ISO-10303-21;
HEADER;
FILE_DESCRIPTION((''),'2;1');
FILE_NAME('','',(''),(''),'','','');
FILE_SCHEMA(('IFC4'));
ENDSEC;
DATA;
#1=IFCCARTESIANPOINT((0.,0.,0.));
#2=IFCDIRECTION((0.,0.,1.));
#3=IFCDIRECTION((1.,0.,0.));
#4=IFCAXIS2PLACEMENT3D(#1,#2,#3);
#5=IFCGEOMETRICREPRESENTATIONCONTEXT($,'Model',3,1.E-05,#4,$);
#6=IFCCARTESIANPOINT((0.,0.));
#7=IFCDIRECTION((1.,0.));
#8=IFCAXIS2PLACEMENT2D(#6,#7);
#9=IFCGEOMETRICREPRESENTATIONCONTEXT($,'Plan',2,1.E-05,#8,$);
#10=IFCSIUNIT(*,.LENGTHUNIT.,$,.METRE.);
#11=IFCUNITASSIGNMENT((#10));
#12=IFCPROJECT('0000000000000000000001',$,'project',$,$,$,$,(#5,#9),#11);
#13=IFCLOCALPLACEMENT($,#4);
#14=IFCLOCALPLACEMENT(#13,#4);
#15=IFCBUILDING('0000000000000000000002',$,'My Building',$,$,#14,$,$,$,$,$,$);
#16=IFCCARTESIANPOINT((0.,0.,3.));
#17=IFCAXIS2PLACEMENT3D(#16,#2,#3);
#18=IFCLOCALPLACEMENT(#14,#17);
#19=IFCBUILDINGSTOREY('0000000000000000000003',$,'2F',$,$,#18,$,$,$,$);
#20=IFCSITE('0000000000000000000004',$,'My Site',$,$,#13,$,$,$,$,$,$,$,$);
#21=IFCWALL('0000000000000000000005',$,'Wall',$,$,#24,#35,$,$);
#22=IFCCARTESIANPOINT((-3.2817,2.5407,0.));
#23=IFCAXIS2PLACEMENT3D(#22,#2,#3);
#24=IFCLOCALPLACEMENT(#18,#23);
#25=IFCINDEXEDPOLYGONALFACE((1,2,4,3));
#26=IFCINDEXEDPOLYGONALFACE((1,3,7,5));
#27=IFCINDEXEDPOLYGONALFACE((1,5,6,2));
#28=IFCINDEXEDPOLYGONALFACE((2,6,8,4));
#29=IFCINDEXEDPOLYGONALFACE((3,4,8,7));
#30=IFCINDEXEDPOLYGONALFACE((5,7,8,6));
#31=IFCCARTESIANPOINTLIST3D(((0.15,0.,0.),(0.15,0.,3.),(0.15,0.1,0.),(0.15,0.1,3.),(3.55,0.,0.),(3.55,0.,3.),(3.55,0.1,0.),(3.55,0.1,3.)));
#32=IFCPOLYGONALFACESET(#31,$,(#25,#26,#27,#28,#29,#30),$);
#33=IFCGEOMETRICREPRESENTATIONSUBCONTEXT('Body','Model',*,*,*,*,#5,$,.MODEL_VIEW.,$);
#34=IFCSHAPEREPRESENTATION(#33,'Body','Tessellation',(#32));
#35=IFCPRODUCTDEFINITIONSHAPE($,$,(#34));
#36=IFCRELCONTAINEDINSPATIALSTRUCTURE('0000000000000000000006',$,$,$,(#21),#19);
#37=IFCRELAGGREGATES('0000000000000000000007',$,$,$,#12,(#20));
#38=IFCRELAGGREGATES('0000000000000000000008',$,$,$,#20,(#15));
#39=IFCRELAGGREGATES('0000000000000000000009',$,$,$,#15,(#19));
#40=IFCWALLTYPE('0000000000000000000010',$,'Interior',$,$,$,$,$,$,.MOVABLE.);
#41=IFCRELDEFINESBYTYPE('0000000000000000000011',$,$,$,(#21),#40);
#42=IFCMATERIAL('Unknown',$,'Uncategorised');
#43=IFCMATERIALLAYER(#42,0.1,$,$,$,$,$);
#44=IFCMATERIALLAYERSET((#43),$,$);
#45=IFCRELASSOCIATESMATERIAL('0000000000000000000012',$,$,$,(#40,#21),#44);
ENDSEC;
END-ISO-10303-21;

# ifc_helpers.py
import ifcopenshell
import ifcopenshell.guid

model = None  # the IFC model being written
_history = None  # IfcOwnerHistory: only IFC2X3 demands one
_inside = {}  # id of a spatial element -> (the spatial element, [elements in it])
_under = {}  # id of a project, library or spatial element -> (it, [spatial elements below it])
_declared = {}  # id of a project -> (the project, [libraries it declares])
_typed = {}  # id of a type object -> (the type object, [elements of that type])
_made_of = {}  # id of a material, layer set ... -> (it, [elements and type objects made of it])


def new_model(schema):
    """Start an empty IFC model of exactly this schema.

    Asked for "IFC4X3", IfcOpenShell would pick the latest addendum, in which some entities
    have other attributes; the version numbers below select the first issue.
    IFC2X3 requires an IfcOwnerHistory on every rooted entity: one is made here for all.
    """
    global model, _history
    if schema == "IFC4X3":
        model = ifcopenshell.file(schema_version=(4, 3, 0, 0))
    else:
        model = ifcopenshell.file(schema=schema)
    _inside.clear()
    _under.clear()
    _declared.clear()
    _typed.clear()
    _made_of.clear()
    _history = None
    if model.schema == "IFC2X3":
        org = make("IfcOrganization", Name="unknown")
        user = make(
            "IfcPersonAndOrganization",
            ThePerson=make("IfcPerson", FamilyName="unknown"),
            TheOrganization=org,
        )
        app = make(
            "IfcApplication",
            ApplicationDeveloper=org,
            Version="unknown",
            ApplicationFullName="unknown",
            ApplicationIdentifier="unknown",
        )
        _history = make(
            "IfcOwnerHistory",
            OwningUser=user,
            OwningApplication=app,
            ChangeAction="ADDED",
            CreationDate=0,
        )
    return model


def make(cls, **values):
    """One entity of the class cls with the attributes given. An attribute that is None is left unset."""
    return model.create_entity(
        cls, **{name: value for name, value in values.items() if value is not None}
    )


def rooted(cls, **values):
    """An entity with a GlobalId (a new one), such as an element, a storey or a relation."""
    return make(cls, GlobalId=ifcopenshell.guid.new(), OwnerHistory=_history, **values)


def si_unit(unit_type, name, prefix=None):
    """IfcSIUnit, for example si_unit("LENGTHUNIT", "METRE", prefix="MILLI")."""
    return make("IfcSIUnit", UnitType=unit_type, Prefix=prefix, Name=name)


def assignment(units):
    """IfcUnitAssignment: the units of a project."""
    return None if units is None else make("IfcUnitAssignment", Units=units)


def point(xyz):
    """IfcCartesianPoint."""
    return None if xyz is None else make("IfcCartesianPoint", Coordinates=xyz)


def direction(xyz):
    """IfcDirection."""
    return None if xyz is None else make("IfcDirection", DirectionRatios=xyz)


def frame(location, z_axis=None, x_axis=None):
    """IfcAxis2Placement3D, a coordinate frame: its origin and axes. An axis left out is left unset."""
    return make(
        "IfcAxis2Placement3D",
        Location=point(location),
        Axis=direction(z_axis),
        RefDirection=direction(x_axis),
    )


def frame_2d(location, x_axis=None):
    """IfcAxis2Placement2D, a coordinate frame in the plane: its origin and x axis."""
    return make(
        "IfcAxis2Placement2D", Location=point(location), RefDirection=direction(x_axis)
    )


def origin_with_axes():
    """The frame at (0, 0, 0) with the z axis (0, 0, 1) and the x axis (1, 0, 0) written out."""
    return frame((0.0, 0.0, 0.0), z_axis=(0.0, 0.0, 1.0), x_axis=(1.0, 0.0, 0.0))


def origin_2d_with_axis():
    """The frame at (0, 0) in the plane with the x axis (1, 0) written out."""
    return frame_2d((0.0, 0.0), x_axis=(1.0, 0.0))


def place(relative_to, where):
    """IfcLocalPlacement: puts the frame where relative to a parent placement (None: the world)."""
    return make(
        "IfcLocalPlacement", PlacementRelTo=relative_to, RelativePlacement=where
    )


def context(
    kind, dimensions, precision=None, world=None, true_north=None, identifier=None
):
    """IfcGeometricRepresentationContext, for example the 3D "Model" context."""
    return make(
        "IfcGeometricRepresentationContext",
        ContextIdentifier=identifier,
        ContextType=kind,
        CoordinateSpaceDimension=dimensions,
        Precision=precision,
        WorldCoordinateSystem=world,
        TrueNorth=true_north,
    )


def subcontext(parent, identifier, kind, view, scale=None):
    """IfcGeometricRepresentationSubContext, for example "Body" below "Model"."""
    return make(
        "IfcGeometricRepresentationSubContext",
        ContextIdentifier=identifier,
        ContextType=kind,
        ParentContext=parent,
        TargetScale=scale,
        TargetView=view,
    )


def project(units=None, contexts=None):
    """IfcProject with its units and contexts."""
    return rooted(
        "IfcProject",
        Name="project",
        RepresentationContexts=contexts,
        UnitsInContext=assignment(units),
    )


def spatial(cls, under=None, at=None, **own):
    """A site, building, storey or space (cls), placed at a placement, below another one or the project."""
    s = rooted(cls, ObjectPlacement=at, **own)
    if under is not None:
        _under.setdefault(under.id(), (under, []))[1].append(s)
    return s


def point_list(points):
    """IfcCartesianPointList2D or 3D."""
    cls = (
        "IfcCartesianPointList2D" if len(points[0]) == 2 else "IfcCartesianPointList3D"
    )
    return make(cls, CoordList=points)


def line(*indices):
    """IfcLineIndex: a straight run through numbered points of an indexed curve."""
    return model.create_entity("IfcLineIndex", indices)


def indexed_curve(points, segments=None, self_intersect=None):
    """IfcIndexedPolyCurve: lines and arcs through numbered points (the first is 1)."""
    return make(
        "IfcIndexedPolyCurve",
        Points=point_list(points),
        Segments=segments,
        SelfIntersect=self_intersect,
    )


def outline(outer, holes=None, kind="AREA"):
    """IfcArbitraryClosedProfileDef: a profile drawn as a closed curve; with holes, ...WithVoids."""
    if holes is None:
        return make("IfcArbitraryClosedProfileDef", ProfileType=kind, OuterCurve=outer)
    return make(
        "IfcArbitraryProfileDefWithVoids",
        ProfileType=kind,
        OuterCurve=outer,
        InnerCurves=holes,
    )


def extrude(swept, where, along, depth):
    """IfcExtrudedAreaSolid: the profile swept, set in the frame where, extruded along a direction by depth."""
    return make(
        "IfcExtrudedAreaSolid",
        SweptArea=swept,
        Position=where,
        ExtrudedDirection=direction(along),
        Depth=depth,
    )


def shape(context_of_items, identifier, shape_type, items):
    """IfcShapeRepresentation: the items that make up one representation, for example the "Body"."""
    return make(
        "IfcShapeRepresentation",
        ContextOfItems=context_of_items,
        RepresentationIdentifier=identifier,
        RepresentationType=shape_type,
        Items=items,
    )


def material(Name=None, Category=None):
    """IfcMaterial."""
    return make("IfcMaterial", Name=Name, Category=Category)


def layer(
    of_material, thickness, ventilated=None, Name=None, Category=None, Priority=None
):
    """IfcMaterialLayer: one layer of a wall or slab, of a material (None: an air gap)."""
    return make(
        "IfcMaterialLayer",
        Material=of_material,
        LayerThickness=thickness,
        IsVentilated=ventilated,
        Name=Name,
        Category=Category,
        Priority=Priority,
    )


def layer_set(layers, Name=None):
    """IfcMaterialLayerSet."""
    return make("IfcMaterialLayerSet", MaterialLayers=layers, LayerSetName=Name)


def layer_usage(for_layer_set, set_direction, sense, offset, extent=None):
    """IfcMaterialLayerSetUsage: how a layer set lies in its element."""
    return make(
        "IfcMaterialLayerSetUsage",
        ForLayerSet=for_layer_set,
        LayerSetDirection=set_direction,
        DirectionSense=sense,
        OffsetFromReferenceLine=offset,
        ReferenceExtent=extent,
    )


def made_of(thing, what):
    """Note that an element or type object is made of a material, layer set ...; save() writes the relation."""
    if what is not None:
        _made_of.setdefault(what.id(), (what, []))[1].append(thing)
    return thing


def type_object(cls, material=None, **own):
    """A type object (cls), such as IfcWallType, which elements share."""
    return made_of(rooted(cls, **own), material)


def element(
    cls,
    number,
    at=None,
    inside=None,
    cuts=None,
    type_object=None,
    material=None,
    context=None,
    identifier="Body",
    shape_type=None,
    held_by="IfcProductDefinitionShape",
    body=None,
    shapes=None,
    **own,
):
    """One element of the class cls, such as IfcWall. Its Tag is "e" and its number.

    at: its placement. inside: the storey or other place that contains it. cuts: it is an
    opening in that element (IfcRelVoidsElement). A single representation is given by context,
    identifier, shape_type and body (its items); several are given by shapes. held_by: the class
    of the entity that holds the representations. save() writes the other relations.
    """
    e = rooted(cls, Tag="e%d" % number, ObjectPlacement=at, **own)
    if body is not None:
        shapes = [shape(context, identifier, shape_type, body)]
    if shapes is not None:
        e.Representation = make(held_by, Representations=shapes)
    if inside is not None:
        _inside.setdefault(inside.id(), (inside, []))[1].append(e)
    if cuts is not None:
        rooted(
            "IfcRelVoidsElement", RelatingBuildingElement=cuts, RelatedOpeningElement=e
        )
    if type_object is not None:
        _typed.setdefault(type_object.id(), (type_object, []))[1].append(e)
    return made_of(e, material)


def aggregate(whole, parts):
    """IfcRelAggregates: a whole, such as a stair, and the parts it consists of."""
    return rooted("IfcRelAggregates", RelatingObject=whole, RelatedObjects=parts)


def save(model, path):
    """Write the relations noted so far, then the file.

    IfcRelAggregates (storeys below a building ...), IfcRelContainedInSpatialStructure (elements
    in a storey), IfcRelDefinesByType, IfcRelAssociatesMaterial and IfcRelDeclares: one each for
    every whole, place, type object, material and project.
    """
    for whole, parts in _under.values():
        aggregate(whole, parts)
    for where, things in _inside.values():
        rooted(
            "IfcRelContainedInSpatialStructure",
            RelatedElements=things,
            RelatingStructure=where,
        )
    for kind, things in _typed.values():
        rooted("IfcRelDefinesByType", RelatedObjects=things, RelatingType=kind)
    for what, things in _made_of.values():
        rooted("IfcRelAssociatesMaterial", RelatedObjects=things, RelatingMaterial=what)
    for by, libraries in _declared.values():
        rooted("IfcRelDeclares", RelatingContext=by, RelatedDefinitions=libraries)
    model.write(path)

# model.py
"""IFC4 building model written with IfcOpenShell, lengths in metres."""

from ifc_helpers import new_model, si_unit, frame, origin_with_axes, origin_2d_with_axis, place, context, subcontext, project, spatial, line, indexed_curve, outline, extrude, material, layer, layer_set, layer_usage, type_object, element, save


model = new_model("IFC4")

# Units and contexts
model_context = context("Model", 3, precision=1e-05, world=origin_with_axes())
plan_context = context("Plan", 2, precision=1e-05, world=origin_2d_with_axis())
body_context_1 = subcontext(model_context, "Body", "Model", "MODEL_VIEW")
ifc_project = project(units=[si_unit("LENGTHUNIT", "METRE")], contexts=[model_context, plan_context])

# Site, building, storey
site_placement = place(None, origin_with_axes())
site = spatial("IfcSite", under=ifc_project, at=site_placement, Name="My Site")
building_placement = place(site_placement, origin_with_axes())
building = spatial("IfcBuilding", under=site, at=building_placement, Name="My Building")
storey_placement = place(building_placement, frame((0.0, 0.0, 3.0), z_axis=(0.0, 0.0, 1.0), x_axis=(1.0, 0.0, 0.0)))
storey = spatial("IfcBuildingStorey", under=building, at=storey_placement, Name="2F")

# Shared definitions
ifc_material = material(Name="Unknown", Category="Uncategorised")

# Shared definitions
ifc_layer_1 = layer(ifc_material, 0.1)
ifc_layer_set_1 = layer_set([ifc_layer_1])
wall_type_1 = type_object("IfcWallType", Name="Interior", PredefinedType="MOVABLE", material=ifc_layer_set_1)

# Wall
ifc_layer_usage_1 = layer_usage(ifc_layer_set_1, "AXIS2", "POSITIVE", 0.0)
wall_1_placement = place(storey_placement, frame((-3.2817, 2.5407, 0.0), z_axis=(0.0, 0.0, 1.0), x_axis=(1.0, 0.0, 0.0)))
element("IfcWall", 1, at=wall_1_placement, inside=storey, type_object=wall_type_1, material=ifc_layer_usage_1, Name="Wall", context=body_context_1, shape_type="SweptSolid", body=[
    extrude(outline(indexed_curve([(0.15, 0.0), (0.15, 0.1), (3.55, 0.1), (3.55, 0.0)], segments=[line(1, 2, 3, 4, 1)])), origin_with_axes(), (0.0, 0.0, 1.0), 3.0),
])

save(model, "model.ifc")
